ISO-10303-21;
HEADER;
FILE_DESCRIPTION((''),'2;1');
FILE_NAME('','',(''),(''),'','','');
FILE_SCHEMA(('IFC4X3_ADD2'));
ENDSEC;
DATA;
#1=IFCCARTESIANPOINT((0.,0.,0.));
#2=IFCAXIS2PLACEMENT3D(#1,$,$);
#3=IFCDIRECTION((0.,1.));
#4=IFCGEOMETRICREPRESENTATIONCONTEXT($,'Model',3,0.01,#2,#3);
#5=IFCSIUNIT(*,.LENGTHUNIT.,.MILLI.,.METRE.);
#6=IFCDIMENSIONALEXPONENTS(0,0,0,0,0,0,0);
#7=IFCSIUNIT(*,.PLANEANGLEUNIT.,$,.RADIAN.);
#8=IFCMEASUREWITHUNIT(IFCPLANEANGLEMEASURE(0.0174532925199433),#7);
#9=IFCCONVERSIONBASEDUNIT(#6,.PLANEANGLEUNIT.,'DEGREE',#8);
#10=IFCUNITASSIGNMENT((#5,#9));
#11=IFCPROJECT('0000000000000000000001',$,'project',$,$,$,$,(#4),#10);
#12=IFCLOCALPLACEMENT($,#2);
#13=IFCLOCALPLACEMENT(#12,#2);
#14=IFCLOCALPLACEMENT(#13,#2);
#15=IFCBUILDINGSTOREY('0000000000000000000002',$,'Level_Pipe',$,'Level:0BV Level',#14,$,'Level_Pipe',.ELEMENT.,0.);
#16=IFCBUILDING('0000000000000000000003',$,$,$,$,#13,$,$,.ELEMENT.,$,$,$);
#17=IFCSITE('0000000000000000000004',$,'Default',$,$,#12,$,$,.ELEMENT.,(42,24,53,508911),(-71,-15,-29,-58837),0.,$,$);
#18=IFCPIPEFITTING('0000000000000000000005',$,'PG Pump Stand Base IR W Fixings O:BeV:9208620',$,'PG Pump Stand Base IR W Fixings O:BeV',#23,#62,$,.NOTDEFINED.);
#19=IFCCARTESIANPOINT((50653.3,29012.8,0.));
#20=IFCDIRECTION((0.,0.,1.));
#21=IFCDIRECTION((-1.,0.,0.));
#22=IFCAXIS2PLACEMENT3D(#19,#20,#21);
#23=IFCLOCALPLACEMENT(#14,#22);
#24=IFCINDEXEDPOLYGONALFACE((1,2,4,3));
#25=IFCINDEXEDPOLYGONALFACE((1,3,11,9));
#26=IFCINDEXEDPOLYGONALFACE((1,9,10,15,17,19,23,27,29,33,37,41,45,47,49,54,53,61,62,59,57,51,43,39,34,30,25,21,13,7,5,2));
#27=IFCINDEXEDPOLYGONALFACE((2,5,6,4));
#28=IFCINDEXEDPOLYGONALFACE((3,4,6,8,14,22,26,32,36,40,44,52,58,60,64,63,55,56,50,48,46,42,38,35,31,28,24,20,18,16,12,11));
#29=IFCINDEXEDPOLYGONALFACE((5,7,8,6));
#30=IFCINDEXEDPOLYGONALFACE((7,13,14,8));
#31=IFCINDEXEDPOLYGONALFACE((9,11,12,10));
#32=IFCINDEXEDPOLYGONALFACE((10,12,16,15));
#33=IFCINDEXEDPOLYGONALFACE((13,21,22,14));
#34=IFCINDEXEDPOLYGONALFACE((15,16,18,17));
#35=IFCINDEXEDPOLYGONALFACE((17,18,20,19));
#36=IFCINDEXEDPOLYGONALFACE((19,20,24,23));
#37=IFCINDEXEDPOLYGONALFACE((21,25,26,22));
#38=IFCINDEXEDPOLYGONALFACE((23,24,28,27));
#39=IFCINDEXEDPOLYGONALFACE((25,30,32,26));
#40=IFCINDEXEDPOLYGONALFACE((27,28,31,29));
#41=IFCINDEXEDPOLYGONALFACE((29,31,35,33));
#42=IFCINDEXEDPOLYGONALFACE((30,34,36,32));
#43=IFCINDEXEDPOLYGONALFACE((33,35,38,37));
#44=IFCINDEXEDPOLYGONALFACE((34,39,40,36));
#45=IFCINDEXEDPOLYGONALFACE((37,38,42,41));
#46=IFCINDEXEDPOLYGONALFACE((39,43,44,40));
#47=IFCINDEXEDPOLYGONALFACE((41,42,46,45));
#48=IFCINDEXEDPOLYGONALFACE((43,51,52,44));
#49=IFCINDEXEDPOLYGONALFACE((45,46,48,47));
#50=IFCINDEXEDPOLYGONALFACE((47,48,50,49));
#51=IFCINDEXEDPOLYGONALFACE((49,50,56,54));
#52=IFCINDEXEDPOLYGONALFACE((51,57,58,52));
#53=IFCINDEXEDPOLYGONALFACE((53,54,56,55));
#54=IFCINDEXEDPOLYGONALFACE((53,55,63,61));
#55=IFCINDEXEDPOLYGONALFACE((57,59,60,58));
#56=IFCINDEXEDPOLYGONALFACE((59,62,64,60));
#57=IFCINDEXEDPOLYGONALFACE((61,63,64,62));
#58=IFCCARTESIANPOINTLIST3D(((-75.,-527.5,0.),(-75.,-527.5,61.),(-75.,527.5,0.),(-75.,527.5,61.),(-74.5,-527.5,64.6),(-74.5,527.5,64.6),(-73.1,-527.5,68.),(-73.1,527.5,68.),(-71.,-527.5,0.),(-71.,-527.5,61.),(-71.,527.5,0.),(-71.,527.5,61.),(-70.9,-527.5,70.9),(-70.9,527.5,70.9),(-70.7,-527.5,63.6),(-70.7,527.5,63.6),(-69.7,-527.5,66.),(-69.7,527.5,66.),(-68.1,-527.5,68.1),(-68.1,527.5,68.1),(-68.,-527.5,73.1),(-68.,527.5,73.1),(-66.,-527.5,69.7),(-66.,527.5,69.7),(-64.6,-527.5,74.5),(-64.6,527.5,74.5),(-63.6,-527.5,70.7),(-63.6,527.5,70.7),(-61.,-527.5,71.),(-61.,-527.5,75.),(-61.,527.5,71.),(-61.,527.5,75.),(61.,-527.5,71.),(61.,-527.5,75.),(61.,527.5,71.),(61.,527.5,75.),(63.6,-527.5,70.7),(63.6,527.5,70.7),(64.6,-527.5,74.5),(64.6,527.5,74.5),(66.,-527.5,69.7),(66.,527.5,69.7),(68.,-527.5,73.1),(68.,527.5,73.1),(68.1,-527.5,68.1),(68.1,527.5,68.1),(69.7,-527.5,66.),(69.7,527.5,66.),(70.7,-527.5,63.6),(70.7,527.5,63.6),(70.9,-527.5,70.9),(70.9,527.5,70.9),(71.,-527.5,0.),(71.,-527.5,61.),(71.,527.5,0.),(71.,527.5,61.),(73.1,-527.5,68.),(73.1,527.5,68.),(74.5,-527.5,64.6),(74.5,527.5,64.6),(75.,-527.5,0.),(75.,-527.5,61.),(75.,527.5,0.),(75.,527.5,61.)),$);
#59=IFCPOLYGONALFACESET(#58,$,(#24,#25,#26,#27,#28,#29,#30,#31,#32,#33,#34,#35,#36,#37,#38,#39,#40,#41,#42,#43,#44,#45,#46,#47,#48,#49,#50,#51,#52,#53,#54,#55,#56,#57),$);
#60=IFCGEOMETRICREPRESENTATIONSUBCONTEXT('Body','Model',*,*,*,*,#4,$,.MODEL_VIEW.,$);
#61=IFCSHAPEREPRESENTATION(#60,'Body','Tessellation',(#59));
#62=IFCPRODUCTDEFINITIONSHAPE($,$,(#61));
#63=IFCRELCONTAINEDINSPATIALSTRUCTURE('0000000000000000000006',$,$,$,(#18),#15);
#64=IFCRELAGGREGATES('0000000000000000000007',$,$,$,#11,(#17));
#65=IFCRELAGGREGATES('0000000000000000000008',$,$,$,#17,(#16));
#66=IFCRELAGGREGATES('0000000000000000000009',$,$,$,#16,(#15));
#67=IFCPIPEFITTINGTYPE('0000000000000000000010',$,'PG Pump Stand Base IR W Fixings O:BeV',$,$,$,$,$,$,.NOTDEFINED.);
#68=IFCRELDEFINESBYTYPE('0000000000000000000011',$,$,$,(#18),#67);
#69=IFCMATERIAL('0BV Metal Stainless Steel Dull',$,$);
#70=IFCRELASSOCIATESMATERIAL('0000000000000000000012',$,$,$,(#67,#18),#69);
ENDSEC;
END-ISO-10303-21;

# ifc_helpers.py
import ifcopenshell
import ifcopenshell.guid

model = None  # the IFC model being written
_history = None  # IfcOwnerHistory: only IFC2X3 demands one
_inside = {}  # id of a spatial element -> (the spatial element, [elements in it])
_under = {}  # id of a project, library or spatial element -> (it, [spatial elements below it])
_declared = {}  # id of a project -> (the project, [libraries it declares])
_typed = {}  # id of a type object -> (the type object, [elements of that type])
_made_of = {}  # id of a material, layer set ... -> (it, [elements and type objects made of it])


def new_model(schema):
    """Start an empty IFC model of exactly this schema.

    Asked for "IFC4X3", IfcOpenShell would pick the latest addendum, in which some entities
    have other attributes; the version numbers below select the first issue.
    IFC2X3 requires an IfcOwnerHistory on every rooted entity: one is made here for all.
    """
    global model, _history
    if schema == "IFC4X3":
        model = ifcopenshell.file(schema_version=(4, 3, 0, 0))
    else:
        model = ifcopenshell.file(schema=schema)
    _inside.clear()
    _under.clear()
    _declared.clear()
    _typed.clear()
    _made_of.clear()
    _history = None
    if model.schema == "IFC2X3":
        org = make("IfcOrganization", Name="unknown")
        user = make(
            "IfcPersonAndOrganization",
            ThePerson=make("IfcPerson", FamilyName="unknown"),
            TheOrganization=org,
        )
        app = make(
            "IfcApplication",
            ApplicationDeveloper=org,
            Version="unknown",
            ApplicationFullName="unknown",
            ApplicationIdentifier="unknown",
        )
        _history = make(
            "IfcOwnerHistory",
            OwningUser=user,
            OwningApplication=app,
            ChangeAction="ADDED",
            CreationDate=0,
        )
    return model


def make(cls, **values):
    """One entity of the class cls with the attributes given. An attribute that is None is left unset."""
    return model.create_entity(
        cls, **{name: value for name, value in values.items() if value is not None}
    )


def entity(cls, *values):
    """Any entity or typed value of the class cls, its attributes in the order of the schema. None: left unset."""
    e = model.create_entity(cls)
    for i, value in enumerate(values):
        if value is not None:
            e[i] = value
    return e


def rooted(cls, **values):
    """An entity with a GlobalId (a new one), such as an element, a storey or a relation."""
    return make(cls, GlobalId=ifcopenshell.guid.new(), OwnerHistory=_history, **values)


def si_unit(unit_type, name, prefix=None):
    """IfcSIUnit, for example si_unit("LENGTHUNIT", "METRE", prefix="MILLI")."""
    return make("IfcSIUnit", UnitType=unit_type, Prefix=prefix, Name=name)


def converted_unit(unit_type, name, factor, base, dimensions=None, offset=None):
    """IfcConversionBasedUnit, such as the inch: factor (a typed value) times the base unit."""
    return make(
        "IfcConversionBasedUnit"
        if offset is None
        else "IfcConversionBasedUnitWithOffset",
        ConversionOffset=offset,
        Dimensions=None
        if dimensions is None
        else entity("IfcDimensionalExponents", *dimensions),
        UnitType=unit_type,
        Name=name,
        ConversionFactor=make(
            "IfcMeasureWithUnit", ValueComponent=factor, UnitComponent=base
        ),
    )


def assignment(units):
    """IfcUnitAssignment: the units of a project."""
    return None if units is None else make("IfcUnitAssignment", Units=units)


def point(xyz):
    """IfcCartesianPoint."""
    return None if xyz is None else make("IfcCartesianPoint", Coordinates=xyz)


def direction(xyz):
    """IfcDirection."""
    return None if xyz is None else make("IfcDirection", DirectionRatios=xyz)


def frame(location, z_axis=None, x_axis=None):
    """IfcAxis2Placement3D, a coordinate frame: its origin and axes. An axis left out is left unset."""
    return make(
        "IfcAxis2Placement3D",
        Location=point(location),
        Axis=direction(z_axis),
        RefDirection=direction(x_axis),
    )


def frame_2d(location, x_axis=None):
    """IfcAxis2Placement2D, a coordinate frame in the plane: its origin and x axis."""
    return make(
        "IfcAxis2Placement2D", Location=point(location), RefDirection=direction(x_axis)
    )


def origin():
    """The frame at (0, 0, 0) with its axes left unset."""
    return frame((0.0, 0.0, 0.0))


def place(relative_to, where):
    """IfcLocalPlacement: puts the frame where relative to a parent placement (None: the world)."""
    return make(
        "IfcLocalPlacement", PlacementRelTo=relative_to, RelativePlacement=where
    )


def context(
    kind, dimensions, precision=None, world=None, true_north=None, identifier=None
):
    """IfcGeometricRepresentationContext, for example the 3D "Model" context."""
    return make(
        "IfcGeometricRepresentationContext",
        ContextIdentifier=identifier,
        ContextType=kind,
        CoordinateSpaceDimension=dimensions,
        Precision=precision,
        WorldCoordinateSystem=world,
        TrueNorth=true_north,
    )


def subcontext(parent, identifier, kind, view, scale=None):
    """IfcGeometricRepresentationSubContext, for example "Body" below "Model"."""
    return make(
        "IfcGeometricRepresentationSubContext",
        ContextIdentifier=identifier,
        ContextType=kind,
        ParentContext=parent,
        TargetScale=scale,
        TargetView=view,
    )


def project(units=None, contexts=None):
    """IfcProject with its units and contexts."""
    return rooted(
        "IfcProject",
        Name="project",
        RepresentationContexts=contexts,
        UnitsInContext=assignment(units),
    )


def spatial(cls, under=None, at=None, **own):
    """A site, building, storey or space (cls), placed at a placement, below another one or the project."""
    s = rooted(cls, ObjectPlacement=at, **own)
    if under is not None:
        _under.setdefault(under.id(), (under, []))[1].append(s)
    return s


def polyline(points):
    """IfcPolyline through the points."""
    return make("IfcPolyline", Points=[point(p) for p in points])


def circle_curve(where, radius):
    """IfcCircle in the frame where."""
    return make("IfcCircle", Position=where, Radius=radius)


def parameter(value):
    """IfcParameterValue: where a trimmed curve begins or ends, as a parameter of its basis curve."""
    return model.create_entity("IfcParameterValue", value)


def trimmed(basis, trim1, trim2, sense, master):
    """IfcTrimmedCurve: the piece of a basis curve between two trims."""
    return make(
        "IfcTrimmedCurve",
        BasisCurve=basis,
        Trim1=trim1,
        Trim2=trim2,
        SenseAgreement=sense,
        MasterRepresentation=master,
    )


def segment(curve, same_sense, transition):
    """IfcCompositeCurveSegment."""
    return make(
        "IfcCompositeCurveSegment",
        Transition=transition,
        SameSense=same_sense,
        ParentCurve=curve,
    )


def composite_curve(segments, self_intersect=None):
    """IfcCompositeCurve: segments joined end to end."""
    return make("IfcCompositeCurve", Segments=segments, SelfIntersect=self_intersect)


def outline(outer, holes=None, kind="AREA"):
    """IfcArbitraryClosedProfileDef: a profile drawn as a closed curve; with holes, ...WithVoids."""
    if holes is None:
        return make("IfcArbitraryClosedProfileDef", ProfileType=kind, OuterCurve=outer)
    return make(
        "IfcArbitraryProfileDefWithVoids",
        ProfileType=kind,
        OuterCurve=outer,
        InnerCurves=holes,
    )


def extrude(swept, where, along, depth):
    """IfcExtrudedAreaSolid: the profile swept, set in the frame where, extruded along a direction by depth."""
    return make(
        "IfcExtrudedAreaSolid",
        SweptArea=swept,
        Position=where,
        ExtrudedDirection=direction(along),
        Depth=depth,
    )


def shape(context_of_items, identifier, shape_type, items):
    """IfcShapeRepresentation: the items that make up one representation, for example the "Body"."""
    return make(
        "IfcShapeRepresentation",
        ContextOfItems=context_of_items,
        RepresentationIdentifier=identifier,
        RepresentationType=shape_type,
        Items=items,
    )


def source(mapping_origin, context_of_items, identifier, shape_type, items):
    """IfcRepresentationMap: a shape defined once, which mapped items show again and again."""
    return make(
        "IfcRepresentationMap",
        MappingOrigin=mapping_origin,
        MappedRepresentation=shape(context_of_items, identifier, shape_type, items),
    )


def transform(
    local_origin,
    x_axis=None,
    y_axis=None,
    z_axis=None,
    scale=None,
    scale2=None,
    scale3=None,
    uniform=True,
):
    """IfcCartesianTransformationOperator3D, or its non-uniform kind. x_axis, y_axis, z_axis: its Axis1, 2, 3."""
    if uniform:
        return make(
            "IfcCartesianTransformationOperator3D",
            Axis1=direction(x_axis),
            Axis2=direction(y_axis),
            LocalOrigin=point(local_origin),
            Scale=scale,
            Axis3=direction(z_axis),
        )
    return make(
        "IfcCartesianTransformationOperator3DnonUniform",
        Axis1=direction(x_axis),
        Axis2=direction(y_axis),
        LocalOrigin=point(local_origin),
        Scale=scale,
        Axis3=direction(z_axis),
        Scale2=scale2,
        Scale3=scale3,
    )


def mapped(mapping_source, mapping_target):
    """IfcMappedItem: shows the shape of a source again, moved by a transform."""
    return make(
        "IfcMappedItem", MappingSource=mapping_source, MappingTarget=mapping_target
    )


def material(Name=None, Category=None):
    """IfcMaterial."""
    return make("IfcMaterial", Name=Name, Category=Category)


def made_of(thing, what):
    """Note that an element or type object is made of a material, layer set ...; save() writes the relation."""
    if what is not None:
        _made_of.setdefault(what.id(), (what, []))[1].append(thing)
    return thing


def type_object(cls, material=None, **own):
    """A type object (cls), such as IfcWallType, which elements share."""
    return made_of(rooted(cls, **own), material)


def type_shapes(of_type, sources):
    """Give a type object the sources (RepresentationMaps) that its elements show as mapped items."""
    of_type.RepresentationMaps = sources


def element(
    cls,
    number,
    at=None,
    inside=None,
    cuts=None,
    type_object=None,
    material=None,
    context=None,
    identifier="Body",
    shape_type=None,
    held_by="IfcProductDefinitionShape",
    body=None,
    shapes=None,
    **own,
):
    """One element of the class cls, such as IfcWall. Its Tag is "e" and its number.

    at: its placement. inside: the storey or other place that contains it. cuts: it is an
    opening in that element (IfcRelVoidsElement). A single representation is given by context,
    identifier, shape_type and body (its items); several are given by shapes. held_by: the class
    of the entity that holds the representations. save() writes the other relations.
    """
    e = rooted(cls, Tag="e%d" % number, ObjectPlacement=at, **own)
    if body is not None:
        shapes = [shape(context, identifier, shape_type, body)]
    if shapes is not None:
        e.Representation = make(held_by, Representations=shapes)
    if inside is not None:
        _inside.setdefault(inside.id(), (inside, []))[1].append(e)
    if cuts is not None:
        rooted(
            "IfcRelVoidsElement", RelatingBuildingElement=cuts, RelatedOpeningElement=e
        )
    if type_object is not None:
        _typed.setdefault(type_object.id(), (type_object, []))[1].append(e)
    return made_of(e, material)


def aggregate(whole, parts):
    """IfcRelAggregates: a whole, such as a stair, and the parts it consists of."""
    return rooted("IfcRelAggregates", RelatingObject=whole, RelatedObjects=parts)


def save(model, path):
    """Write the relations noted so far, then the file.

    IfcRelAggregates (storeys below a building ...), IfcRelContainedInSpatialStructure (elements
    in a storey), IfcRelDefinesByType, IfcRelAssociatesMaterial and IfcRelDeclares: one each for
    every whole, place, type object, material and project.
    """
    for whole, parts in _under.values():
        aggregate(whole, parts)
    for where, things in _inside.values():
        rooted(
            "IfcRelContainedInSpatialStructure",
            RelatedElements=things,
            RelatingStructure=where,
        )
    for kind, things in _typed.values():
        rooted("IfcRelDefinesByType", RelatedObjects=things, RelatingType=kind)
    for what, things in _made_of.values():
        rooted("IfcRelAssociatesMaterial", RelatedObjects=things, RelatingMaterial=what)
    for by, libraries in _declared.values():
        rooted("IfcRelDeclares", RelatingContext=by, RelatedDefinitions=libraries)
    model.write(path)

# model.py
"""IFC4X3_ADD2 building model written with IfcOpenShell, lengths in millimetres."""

from ifc_helpers import new_model, entity, si_unit, converted_unit, direction, frame, frame_2d, origin, place, context, subcontext, project, spatial, polyline, circle_curve, parameter, trimmed, segment, composite_curve, outline, extrude, source, transform, mapped, material, type_object, type_shapes, element, save


model = new_model("IFC4X3_ADD2")

# Units and contexts
model_context = context("Model", 3, precision=0.01, world=origin(), true_north=direction((0.0, 1.0)))
body_context = subcontext(model_context, "Body", "Model", "MODEL_VIEW")
ifc_project = project(units=[si_unit("LENGTHUNIT", "METRE", prefix="MILLI"), converted_unit("PLANEANGLEUNIT", "DEGREE", entity("IfcPlaneAngleMeasure", 0.0174532925199433), si_unit("PLANEANGLEUNIT", "RADIAN"), dimensions=[0, 0, 0, 0, 0, 0, 0])], contexts=[model_context])

# Site, building, storey
site_placement = place(None, origin())
site = spatial("IfcSite", under=ifc_project, at=site_placement, Name="Default", CompositionType="ELEMENT", RefLatitude=(42, 24, 53, 508911), RefLongitude=(-71, -15, -29, -58837), RefElevation=0.0)
building_placement = place(site_placement, origin())
building = spatial("IfcBuilding", under=site, at=building_placement, CompositionType="ELEMENT")
storey_placement = place(building_placement, origin())
storey = spatial("IfcBuildingStorey", under=building, at=storey_placement, Name="Level_Pipe", ObjectType="Level:0BV Level", LongName="Level_Pipe", CompositionType="ELEMENT", Elevation=0.0)

# Pipe fitting
ifc_material_1 = material(Name="0BV Metal Stainless Steel Dull")
pipe_fitting_type_1 = type_object("IfcPipeFittingType", Name="PG Pump Stand Base IR W Fixings O:BeV", PredefinedType="NOTDEFINED", material=ifc_material_1)
shared_shape_1 = source(origin(), body_context, "Body", "SweptSolid", [
    extrude(outline(composite_curve([segment(polyline([(71.0, -44.7), (75.0, -44.7)]), True, "CONTINUOUS"), segment(polyline([(75.0, -44.7), (75.0, 16.3)]), True, "CONTINUOUS"), segment(trimmed(circle_curve(frame_2d((61.0, 16.3), x_axis=(-1.0, 0.0)), 14.0), [parameter(180.0)], [parameter(270.0)], True, "PARAMETER"), True, "CONTINUOUS"), segment(polyline([(61.0, 30.3), (-61.0, 30.3)]), True, "CONTINUOUS"), segment(trimmed(circle_curve(frame_2d((-61.0, 16.3), x_axis=(-1.0, 0.0)), 14.0), [parameter(270.0)], [parameter(0.0)], True, "PARAMETER"), True, "CONTINUOUS"), segment(polyline([(-75.0, 16.3), (-75.0, -44.7)]), True, "CONTINUOUS"), segment(polyline([(-75.0, -44.7), (-71.0, -44.7)]), True, "CONTINUOUS"), segment(polyline([(-71.0, -44.7), (-71.0, 16.3)]), True, "CONTINUOUS"), segment(trimmed(circle_curve(frame_2d((-61.0, 16.3), x_axis=(-1.0, 0.0)), 10.0), [parameter(270.0)], [parameter(0.0)], True, "PARAMETER"), False, "CONTINUOUS"), segment(polyline([(-61.0, 26.3), (61.0, 26.3)]), True, "CONTINUOUS"), segment(trimmed(circle_curve(frame_2d((61.0, 16.3), x_axis=(-1.0, 0.0)), 10.0), [parameter(180.0)], [parameter(270.0)], True, "PARAMETER"), False, "CONTINUOUS"), segment(polyline([(71.0, 16.3), (71.0, -44.7)]), True, "CONTINUOUS")], self_intersect=False)), frame((0.0, -527.5, 44.7), z_axis=(0.0, 1.0, 0.0), x_axis=(-1.0, 0.0, 0.0)), (0.0, 0.0, 1.0), 1055.0),
])
type_shapes(pipe_fitting_type_1, [shared_shape_1])
pipe_fitting_1_placement = place(storey_placement, frame((50653.3, 29012.8, 0.0), z_axis=(0.0, 0.0, 1.0), x_axis=(-1.0, 0.0, 0.0)))
element("IfcPipeFitting", 1, at=pipe_fitting_1_placement, inside=storey, type_object=pipe_fitting_type_1, material=ifc_material_1, Name="PG Pump Stand Base IR W Fixings O:BeV:9208620", ObjectType="PG Pump Stand Base IR W Fixings O:BeV", PredefinedType="NOTDEFINED", context=body_context, shape_type="MappedRepresentation", body=[
    mapped(shared_shape_1, transform((0.0, 0.0, 0.0), scale=1.0)),
])

save(model, "model.ifc")
